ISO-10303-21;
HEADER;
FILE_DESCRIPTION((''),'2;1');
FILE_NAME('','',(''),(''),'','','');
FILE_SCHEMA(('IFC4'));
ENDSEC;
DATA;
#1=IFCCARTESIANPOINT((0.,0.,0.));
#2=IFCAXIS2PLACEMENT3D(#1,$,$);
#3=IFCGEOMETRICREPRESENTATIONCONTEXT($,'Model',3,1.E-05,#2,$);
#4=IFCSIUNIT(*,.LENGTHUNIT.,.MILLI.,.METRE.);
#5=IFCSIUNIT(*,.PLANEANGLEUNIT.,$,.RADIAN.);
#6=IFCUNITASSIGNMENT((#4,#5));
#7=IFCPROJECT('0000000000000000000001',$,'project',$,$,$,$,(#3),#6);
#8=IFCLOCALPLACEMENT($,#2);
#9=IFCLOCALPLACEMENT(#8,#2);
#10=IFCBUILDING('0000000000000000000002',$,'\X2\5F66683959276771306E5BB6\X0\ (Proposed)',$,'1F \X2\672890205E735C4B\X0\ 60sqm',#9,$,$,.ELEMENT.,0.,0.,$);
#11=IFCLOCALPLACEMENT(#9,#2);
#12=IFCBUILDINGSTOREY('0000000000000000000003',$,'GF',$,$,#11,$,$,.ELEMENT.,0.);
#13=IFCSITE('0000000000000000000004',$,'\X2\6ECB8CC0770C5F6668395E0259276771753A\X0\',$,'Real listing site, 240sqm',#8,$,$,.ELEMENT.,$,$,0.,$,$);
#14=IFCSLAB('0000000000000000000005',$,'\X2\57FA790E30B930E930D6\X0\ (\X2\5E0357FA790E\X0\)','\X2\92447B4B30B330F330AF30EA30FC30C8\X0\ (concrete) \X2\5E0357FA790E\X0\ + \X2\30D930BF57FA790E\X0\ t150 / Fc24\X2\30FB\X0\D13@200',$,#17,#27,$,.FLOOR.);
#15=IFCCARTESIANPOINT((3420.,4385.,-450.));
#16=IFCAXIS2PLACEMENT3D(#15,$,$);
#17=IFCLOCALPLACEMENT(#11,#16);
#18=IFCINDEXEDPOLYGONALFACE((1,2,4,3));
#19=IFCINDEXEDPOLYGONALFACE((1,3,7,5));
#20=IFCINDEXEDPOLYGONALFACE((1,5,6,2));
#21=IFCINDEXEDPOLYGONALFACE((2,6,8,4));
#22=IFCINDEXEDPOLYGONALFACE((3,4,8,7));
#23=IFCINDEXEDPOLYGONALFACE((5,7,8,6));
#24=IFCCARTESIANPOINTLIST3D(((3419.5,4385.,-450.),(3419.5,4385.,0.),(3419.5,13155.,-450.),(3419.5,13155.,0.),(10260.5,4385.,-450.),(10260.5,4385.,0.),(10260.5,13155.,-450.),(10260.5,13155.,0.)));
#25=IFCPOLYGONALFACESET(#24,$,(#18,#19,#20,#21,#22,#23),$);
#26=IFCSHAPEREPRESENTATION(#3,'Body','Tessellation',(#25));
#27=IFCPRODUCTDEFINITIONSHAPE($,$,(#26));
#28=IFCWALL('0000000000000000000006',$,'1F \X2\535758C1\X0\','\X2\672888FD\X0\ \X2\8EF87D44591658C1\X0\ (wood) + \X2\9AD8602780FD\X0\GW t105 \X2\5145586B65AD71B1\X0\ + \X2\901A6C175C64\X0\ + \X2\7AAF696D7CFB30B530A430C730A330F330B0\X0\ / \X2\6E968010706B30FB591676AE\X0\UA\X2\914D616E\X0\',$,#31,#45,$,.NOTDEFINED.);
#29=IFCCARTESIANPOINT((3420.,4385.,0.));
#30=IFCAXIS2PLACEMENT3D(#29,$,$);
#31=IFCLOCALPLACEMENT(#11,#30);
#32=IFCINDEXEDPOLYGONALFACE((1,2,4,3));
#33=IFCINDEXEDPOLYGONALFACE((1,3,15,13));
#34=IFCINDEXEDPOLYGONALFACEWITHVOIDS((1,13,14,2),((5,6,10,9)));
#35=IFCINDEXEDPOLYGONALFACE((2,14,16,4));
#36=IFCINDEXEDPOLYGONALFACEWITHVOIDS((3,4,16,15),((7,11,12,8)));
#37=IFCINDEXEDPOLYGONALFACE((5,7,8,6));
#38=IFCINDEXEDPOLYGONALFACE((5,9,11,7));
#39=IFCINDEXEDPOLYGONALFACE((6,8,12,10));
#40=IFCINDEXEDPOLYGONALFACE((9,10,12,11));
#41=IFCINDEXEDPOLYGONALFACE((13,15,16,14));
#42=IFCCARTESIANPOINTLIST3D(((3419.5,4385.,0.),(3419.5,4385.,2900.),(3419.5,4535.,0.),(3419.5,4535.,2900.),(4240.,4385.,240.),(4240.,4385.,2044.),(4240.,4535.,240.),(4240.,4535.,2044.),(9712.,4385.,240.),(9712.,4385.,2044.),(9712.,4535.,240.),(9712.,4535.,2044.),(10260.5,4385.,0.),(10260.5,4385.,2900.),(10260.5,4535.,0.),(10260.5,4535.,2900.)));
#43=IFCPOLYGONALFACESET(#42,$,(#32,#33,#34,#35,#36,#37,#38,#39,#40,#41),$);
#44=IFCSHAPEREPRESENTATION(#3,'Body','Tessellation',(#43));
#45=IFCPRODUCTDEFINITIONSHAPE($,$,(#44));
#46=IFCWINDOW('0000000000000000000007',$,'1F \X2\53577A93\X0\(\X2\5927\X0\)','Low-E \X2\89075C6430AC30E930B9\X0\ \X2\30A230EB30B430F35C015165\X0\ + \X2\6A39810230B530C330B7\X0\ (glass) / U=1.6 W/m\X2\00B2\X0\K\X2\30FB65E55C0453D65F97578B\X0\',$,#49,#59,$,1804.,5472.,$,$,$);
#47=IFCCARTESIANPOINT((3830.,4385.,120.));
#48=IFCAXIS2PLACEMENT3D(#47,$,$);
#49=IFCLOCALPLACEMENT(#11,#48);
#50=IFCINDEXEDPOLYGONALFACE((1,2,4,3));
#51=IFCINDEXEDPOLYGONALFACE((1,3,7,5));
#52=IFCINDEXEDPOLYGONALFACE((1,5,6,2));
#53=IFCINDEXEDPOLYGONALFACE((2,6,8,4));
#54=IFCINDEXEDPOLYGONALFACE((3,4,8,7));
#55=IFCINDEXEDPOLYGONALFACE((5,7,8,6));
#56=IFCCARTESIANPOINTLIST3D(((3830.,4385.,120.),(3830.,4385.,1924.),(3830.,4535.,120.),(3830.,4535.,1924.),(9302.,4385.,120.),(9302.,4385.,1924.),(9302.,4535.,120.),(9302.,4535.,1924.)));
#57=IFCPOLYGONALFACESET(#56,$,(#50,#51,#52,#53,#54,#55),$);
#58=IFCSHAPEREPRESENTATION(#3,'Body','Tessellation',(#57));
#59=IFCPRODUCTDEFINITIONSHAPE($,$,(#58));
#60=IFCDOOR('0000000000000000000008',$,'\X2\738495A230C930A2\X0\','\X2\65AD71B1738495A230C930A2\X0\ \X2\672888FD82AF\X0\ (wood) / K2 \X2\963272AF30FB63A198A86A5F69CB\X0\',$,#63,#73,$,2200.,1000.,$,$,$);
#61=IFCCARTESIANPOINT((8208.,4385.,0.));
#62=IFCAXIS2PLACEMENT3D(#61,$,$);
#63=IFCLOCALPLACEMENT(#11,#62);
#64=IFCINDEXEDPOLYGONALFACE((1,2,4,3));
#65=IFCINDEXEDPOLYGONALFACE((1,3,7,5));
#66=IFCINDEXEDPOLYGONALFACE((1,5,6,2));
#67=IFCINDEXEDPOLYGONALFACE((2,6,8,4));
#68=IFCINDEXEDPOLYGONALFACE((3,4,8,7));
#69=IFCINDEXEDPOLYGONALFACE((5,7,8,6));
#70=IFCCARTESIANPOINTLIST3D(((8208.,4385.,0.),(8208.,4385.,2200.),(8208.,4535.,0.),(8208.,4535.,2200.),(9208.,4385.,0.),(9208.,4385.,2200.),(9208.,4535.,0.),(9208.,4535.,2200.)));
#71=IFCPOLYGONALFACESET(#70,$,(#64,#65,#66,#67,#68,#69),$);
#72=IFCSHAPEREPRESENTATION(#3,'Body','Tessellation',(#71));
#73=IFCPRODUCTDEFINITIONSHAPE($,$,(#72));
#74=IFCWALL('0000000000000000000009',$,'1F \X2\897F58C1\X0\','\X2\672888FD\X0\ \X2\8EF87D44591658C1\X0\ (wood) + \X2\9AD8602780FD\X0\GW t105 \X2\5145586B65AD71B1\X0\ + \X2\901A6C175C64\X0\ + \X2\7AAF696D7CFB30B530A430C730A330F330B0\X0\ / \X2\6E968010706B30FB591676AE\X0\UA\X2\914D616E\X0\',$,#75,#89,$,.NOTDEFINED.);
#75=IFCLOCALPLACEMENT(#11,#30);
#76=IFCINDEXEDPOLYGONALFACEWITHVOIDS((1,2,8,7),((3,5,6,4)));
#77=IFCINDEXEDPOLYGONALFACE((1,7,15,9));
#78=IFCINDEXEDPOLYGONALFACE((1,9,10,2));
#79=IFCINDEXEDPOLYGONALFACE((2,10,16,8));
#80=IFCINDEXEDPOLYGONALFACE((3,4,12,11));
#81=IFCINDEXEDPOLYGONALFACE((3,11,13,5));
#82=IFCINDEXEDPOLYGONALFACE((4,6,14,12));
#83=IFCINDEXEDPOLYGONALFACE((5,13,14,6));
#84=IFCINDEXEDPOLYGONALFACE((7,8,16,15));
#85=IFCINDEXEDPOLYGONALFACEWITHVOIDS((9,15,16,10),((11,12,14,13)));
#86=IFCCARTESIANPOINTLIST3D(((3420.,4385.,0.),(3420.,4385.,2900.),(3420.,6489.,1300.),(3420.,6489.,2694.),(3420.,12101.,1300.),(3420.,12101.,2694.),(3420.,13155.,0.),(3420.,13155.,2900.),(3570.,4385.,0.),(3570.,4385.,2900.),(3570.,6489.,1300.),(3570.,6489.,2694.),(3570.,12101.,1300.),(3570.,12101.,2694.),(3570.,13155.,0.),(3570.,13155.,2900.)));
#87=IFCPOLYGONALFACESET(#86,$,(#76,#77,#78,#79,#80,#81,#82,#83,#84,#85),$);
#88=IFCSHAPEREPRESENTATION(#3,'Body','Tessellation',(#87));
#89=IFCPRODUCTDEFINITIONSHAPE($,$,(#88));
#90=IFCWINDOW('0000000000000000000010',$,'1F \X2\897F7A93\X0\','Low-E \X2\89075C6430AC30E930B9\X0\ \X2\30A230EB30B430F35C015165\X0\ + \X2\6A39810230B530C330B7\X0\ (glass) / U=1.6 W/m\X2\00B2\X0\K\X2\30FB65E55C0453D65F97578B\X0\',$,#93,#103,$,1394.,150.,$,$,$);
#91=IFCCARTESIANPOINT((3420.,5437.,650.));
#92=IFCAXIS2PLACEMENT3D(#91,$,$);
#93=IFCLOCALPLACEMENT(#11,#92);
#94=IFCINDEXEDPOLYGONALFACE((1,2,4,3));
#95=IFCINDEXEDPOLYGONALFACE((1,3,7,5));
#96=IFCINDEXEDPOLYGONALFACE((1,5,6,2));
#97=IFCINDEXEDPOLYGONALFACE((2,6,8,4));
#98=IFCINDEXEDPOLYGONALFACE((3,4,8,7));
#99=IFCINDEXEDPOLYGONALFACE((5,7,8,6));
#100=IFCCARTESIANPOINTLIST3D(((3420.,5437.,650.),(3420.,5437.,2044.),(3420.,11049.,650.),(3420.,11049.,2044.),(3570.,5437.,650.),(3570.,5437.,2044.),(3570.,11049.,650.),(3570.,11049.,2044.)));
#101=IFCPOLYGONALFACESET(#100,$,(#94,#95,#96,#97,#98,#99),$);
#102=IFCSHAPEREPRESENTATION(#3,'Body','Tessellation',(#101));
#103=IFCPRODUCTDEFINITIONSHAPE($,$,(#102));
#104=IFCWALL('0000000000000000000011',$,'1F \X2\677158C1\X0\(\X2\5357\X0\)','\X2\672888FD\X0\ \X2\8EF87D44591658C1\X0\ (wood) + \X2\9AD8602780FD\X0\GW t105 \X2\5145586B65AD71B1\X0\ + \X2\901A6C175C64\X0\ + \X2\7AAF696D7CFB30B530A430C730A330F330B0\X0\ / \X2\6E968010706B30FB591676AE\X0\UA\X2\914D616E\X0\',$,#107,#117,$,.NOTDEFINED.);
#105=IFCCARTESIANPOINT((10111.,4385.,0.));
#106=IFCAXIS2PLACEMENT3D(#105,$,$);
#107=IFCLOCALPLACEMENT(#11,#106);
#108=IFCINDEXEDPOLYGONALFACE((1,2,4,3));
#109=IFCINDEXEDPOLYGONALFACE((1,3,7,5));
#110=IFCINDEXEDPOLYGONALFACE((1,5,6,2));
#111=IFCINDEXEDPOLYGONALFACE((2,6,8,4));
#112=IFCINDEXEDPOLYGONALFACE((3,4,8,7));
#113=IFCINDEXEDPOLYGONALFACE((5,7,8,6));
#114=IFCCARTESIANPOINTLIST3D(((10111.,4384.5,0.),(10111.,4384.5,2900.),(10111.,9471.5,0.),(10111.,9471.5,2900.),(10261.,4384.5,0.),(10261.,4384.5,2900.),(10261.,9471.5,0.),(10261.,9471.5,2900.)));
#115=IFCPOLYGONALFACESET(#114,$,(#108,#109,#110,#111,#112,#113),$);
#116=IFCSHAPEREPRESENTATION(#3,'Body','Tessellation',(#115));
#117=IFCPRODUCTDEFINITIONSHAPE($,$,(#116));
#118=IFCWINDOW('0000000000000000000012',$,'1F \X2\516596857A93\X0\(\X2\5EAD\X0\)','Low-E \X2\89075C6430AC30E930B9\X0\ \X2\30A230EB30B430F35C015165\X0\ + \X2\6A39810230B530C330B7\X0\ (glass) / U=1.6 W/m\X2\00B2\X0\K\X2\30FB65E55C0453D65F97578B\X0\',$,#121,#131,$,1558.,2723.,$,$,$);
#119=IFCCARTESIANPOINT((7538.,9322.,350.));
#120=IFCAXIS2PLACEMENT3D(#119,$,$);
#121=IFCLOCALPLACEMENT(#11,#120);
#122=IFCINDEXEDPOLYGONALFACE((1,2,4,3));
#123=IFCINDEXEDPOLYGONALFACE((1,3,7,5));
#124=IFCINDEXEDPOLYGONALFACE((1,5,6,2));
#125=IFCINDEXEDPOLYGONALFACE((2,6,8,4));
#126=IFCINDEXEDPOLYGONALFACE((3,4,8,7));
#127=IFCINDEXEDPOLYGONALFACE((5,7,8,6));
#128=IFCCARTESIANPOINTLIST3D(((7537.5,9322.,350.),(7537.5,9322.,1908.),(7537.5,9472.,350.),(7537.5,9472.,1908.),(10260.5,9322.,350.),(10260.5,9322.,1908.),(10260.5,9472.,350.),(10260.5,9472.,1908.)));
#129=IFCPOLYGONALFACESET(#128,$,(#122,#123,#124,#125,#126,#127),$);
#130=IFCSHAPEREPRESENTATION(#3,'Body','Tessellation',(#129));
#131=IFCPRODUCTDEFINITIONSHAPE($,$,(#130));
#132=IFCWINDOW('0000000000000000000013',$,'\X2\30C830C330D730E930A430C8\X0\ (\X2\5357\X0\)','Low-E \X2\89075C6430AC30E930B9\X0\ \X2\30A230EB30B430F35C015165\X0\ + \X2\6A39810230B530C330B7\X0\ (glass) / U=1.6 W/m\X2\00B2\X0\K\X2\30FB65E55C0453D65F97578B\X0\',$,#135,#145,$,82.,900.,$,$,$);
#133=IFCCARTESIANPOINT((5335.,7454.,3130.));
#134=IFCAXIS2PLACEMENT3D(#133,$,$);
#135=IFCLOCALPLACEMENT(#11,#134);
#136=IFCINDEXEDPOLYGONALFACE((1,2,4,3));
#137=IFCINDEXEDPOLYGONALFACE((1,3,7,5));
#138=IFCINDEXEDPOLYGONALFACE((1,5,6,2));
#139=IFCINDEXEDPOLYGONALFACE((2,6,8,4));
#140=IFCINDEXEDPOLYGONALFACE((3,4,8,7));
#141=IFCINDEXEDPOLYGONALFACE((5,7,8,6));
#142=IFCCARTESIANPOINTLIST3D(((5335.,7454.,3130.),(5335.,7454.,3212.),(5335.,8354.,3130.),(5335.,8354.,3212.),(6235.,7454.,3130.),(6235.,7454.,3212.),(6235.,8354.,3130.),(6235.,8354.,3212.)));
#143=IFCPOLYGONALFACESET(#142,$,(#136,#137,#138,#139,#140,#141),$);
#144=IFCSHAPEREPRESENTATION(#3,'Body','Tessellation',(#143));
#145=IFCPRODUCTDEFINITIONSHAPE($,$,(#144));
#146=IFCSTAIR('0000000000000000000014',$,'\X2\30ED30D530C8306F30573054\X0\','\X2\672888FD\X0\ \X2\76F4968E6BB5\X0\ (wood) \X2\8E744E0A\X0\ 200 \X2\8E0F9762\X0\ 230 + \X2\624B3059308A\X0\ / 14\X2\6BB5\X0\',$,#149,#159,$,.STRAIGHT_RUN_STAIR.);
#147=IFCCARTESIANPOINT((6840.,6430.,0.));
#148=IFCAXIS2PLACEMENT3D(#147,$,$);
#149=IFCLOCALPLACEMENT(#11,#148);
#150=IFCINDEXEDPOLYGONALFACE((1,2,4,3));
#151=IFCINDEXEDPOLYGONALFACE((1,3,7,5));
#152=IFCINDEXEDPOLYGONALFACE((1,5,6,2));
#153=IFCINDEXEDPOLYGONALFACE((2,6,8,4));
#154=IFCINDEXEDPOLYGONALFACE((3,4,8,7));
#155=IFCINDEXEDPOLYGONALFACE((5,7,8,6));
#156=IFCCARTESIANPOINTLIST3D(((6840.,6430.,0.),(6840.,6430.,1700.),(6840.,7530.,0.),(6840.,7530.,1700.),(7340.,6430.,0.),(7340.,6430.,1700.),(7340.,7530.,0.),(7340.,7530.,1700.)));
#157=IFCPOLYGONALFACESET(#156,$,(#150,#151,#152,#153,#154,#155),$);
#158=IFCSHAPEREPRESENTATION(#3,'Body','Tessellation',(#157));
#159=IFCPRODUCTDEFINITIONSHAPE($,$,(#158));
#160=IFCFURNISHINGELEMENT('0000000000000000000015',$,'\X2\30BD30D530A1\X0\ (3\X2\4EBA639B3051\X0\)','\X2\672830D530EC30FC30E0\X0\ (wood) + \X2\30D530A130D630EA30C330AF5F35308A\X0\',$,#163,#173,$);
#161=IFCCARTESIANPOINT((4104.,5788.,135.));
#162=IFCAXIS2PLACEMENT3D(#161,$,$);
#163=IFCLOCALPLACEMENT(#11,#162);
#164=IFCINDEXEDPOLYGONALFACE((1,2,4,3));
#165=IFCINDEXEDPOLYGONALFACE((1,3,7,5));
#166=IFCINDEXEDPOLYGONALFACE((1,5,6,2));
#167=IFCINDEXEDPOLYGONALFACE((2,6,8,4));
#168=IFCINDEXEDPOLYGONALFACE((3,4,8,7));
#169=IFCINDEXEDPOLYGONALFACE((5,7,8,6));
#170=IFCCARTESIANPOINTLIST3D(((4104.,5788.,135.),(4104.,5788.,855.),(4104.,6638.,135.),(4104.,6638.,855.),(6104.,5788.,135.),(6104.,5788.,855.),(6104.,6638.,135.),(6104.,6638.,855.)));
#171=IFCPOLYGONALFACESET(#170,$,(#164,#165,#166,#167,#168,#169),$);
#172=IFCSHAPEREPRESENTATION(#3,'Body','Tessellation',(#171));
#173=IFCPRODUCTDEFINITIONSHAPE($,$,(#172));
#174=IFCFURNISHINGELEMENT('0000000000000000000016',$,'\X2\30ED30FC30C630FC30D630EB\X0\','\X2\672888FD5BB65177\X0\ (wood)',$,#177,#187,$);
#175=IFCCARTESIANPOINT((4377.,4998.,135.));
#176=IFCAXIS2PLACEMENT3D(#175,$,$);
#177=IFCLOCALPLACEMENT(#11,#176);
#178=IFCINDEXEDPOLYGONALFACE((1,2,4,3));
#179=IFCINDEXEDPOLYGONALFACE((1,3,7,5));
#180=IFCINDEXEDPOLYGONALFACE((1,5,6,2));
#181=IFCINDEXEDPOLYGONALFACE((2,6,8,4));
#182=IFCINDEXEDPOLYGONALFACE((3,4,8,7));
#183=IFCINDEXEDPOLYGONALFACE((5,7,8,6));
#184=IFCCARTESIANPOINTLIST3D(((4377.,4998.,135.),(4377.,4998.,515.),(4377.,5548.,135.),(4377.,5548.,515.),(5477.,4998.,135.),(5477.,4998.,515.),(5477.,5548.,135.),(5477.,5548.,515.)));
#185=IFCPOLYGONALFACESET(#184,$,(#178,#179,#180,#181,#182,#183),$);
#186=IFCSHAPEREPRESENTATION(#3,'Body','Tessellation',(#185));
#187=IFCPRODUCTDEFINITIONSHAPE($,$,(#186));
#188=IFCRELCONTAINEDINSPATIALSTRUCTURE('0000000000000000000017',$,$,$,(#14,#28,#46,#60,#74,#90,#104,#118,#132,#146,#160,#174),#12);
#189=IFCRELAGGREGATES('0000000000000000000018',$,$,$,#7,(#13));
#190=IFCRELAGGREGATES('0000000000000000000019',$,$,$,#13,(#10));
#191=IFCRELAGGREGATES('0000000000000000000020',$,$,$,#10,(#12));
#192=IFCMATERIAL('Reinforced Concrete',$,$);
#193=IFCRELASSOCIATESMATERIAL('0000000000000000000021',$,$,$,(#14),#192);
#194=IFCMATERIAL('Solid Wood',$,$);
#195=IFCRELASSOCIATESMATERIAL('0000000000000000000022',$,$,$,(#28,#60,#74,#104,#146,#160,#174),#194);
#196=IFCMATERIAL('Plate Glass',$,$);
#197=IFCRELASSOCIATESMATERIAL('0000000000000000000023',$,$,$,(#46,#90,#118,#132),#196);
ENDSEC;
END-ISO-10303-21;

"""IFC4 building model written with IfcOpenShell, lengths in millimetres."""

from ifc_helpers import new_model, si_unit, frame, frame_2d, origin, place, context, project, spatial, rectangle, extrude, material, element, fill, save


model = new_model("IFC4")

# Units and contexts
model_context = context("Model", 3, precision=1e-05, world=origin())
ifc_project = project(units=[si_unit("LENGTHUNIT", "METRE", prefix="MILLI"), si_unit("PLANEANGLEUNIT", "RADIAN")], contexts=[model_context])

# Site, building, storey
site_placement = place(None, origin())
site = spatial("IfcSite", under=ifc_project, at=site_placement, Name="滋賀県彦根市大東町", ObjectType="Real listing site, 240sqm", CompositionType="ELEMENT", RefElevation=0.0)
building_placement = place(site_placement, origin())
building = spatial("IfcBuilding", under=site, at=building_placement, Name="彦根大東の家 (Proposed)", ObjectType="1F 木造平屋 60sqm", CompositionType="ELEMENT", ElevationOfRefHeight=0.0, ElevationOfTerrain=0.0)
storey_placement = place(building_placement, origin())
storey = spatial("IfcBuildingStorey", under=building, at=storey_placement, Name="GF", CompositionType="ELEMENT", Elevation=0.0)

# Slab
ifc_material_1 = material(Name="Reinforced Concrete")
slab_1_placement = place(storey_placement, frame((3420.0, 4385.0, -450.0)))
element("IfcSlab", 1, at=slab_1_placement, inside=storey, material=ifc_material_1, Name="基礎スラブ (布基礎)", Description="鉄筋コンクリート (concrete) 布基礎 + ベタ基礎 t150 / Fc24・D13@200", PredefinedType="FLOOR", context=model_context, shape_type="SweptSolid", body=[
    extrude(rectangle(XDim=6841.0, YDim=8770.0, at=frame_2d((3420.0, 4385.0))), frame((3420.0, 4385.0, -450.0)), (0.0, 0.0, 1.0), 450.0),
])
ifc_material_2 = material(Name="Solid Wood")

# Wall, openings, window, door
wall_1_placement = place(storey_placement, frame((3420.0, 4385.0, 0.0)))
wall_1 = element("IfcWall", 2, at=wall_1_placement, inside=storey, material=ifc_material_2, Name="1F 南壁", Description="木製 軸組外壁 (wood) + 高性能GW t105 充填断熱 + 通気層 + 窯業系サイディング / 準耐火・外皮UA配慮", PredefinedType="NOTDEFINED", context=model_context, shape_type="SweptSolid", body=[
    extrude(rectangle(XDim=6841.0, YDim=150.0, at=frame_2d((3420.0, 75.0))), frame((3420.0, 4385.0, 0.0)), (0.0, 0.0, 1.0), 2900.0),
])
opening_1_placement = place(storey_placement, frame((3830.0, 4385.0, 120.0)))
opening_1 = element("IfcOpeningElement", 3, at=opening_1_placement, cuts=wall_1, PredefinedType="NOTDEFINED", context=model_context, shape_type="SweptSolid", body=[
    extrude(rectangle(XDim=5472.0, YDim=150.0, at=frame_2d((2736.0, 75.0))), frame((3830.0, 4385.0, 120.0)), (0.0, 0.0, 1.0), 1804.0),
])
opening_2_placement = place(storey_placement, frame((8208.0, 4385.0, 0.0)))
opening_2 = element("IfcOpeningElement", 4, at=opening_2_placement, cuts=wall_1, PredefinedType="NOTDEFINED", context=model_context, shape_type="SweptSolid", body=[
    extrude(rectangle(XDim=1000.0, YDim=150.0, at=frame_2d((500.0, 75.0))), frame((8208.0, 4385.0, 0.0)), (0.0, 0.0, 1.0), 2200.0),
])
ifc_material_3 = material(Name="Plate Glass")
window_1_placement = place(storey_placement, frame((3830.0, 4385.0, 120.0)))
window_1 = element("IfcWindow", 5, at=window_1_placement, inside=storey, material=ifc_material_3, Name="1F 南窓(大)", Description="Low-E 複層ガラス アルゴン封入 + 樹脂サッシ (glass) / U=1.6 W/m²K・日射取得型", OverallHeight=1804.0, OverallWidth=5472.0, context=model_context, shape_type="SweptSolid", body=[
    extrude(rectangle(XDim=5472.0, YDim=150.0, at=frame_2d((2736.0, 75.0))), frame((3830.0, 4385.0, 120.0)), (0.0, 0.0, 1.0), 1804.0),
])
fill(opening_1, window_1)
door_1_placement = place(storey_placement, frame((8208.0, 4385.0, 0.0)))
door_1 = element("IfcDoor", 6, at=door_1_placement, inside=storey, material=ifc_material_2, Name="玄関ドア", Description="断熱玄関ドア 木製芯 (wood) / K2 防犯・採風機構", OverallHeight=2200.0, OverallWidth=1000.0, context=model_context, shape_type="SweptSolid", body=[
    extrude(rectangle(XDim=1000.0, YDim=150.0, at=frame_2d((500.0, 75.0))), frame((8208.0, 4385.0, 0.0)), (0.0, 0.0, 1.0), 2200.0),
])
fill(opening_2, door_1)

# Walls, openings, windows
wall_2_placement = place(storey_placement, frame((3420.0, 4385.0, 0.0)))
wall_2 = element("IfcWall", 7, at=wall_2_placement, inside=storey, material=ifc_material_2, Name="1F 西壁", Description="木製 軸組外壁 (wood) + 高性能GW t105 充填断熱 + 通気層 + 窯業系サイディング / 準耐火・外皮UA配慮", PredefinedType="NOTDEFINED", context=model_context, shape_type="SweptSolid", body=[
    extrude(rectangle(XDim=150.0, YDim=8770.0, at=frame_2d((75.0, 4385.0))), frame((3420.0, 4385.0, 0.0)), (0.0, 0.0, 1.0), 2900.0),
])
opening_3_placement = place(storey_placement, frame((3420.0, 5437.0, 650.0)))
opening_3 = element("IfcOpeningElement", 8, at=opening_3_placement, cuts=wall_2, PredefinedType="NOTDEFINED", context=model_context, shape_type="SweptSolid", body=[
    extrude(rectangle(XDim=150.0, YDim=5612.0, at=frame_2d((75.0, 2806.0))), frame((3420.0, 5437.0, 650.0)), (0.0, 0.0, 1.0), 1394.0),
])
window_2_placement = place(storey_placement, frame((3420.0, 5437.0, 650.0)))
window_2 = element("IfcWindow", 9, at=window_2_placement, inside=storey, material=ifc_material_3, Name="1F 西窓", Description="Low-E 複層ガラス アルゴン封入 + 樹脂サッシ (glass) / U=1.6 W/m²K・日射取得型", OverallHeight=1394.0, OverallWidth=150.0, context=model_context, shape_type="SweptSolid", body=[
    extrude(rectangle(XDim=150.0, YDim=5612.0, at=frame_2d((75.0, 2806.0))), frame((3420.0, 5437.0, 650.0)), (0.0, 0.0, 1.0), 1394.0),
])
fill(opening_3, window_2)
wall_3_placement = place(storey_placement, frame((10111.0, 4385.0, 0.0)))
wall_3 = element("IfcWall", 10, at=wall_3_placement, inside=storey, material=ifc_material_2, Name="1F 東壁(南)", Description="木製 軸組外壁 (wood) + 高性能GW t105 充填断熱 + 通気層 + 窯業系サイディング / 準耐火・外皮UA配慮", PredefinedType="NOTDEFINED", context=model_context, shape_type="SweptSolid", body=[
    extrude(rectangle(XDim=150.0, YDim=5087.0, at=frame_2d((75.0, 2543.0))), frame((10111.0, 4385.0, 0.0)), (0.0, 0.0, 1.0), 2900.0),
])
opening_4_placement = place(storey_placement, frame((7538.0, 9322.0, 350.0)))
opening_4 = element("IfcOpeningElement", 11, at=opening_4_placement, cuts=wall_3, PredefinedType="NOTDEFINED", context=model_context, shape_type="SweptSolid", body=[
    extrude(rectangle(XDim=2723.0, YDim=150.0, at=frame_2d((1361.0, 75.0))), frame((7538.0, 9322.0, 350.0)), (0.0, 0.0, 1.0), 1558.0),
])
window_3_placement = place(storey_placement, frame((7538.0, 9322.0, 350.0)))
window_3 = element("IfcWindow", 12, at=window_3_placement, inside=storey, material=ifc_material_3, Name="1F 入隅窓(庭)", Description="Low-E 複層ガラス アルゴン封入 + 樹脂サッシ (glass) / U=1.6 W/m²K・日射取得型", OverallHeight=1558.0, OverallWidth=2723.0, context=model_context, shape_type="SweptSolid", body=[
    extrude(rectangle(XDim=2723.0, YDim=150.0, at=frame_2d((1361.0, 75.0))), frame((7538.0, 9322.0, 350.0)), (0.0, 0.0, 1.0), 1558.0),
])
fill(opening_4, window_3)

# Window
window_4_placement = place(storey_placement, frame((5335.0, 7454.0, 3130.0)))
element("IfcWindow", 13, at=window_4_placement, inside=storey, material=ifc_material_3, Name="トップライト (南)", Description="Low-E 複層ガラス アルゴン封入 + 樹脂サッシ (glass) / U=1.6 W/m²K・日射取得型", OverallHeight=82.0, OverallWidth=900.0, context=model_context, shape_type="SweptSolid", body=[
    extrude(rectangle(XDim=900.0, YDim=900.0, at=frame_2d((450.0, 450.0))), frame((5335.0, 7454.0, 3130.0)), (0.0, 0.0, 1.0), 82.0),
])

# Stair
stair_placement = place(storey_placement, frame((6840.0, 6430.0, 0.0)))
element("IfcStair", 14, at=stair_placement, inside=storey, material=ifc_material_2, Name="ロフトはしご", Description="木製 直階段 (wood) 蹴上 200 踏面 230 + 手すり / 14段", PredefinedType="STRAIGHT_RUN_STAIR", context=model_context, shape_type="SweptSolid", body=[
    extrude(rectangle(XDim=500.0, YDim=1100.0, at=frame_2d((250.0, 550.0))), frame((6840.0, 6430.0, 0.0)), (0.0, 0.0, 1.0), 1700.0),
])

# Furnishing elements
furnishing_1_placement = place(storey_placement, frame((4104.0, 5788.0, 135.0)))
element("IfcFurnishingElement", 15, at=furnishing_1_placement, inside=storey, material=ifc_material_2, Name="ソファ (3人掛け)", Description="木フレーム (wood) + ファブリック張り", context=model_context, shape_type="SweptSolid", body=[
    extrude(rectangle(XDim=2000.0, YDim=850.0, at=frame_2d((1000.0, 425.0))), frame((4104.0, 5788.0, 135.0)), (0.0, 0.0, 1.0), 720.0),
])
furnishing_2_placement = place(storey_placement, frame((4377.0, 4998.0, 135.0)))
element("IfcFurnishingElement", 16, at=furnishing_2_placement, inside=storey, material=ifc_material_2, Name="ローテーブル", Description="木製家具 (wood)", context=model_context, shape_type="SweptSolid", body=[
    extrude(rectangle(XDim=1100.0, YDim=550.0, at=frame_2d((550.0, 275.0))), frame((4377.0, 4998.0, 135.0)), (0.0, 0.0, 1.0), 380.0),
])

save(model, "model.ifc")
